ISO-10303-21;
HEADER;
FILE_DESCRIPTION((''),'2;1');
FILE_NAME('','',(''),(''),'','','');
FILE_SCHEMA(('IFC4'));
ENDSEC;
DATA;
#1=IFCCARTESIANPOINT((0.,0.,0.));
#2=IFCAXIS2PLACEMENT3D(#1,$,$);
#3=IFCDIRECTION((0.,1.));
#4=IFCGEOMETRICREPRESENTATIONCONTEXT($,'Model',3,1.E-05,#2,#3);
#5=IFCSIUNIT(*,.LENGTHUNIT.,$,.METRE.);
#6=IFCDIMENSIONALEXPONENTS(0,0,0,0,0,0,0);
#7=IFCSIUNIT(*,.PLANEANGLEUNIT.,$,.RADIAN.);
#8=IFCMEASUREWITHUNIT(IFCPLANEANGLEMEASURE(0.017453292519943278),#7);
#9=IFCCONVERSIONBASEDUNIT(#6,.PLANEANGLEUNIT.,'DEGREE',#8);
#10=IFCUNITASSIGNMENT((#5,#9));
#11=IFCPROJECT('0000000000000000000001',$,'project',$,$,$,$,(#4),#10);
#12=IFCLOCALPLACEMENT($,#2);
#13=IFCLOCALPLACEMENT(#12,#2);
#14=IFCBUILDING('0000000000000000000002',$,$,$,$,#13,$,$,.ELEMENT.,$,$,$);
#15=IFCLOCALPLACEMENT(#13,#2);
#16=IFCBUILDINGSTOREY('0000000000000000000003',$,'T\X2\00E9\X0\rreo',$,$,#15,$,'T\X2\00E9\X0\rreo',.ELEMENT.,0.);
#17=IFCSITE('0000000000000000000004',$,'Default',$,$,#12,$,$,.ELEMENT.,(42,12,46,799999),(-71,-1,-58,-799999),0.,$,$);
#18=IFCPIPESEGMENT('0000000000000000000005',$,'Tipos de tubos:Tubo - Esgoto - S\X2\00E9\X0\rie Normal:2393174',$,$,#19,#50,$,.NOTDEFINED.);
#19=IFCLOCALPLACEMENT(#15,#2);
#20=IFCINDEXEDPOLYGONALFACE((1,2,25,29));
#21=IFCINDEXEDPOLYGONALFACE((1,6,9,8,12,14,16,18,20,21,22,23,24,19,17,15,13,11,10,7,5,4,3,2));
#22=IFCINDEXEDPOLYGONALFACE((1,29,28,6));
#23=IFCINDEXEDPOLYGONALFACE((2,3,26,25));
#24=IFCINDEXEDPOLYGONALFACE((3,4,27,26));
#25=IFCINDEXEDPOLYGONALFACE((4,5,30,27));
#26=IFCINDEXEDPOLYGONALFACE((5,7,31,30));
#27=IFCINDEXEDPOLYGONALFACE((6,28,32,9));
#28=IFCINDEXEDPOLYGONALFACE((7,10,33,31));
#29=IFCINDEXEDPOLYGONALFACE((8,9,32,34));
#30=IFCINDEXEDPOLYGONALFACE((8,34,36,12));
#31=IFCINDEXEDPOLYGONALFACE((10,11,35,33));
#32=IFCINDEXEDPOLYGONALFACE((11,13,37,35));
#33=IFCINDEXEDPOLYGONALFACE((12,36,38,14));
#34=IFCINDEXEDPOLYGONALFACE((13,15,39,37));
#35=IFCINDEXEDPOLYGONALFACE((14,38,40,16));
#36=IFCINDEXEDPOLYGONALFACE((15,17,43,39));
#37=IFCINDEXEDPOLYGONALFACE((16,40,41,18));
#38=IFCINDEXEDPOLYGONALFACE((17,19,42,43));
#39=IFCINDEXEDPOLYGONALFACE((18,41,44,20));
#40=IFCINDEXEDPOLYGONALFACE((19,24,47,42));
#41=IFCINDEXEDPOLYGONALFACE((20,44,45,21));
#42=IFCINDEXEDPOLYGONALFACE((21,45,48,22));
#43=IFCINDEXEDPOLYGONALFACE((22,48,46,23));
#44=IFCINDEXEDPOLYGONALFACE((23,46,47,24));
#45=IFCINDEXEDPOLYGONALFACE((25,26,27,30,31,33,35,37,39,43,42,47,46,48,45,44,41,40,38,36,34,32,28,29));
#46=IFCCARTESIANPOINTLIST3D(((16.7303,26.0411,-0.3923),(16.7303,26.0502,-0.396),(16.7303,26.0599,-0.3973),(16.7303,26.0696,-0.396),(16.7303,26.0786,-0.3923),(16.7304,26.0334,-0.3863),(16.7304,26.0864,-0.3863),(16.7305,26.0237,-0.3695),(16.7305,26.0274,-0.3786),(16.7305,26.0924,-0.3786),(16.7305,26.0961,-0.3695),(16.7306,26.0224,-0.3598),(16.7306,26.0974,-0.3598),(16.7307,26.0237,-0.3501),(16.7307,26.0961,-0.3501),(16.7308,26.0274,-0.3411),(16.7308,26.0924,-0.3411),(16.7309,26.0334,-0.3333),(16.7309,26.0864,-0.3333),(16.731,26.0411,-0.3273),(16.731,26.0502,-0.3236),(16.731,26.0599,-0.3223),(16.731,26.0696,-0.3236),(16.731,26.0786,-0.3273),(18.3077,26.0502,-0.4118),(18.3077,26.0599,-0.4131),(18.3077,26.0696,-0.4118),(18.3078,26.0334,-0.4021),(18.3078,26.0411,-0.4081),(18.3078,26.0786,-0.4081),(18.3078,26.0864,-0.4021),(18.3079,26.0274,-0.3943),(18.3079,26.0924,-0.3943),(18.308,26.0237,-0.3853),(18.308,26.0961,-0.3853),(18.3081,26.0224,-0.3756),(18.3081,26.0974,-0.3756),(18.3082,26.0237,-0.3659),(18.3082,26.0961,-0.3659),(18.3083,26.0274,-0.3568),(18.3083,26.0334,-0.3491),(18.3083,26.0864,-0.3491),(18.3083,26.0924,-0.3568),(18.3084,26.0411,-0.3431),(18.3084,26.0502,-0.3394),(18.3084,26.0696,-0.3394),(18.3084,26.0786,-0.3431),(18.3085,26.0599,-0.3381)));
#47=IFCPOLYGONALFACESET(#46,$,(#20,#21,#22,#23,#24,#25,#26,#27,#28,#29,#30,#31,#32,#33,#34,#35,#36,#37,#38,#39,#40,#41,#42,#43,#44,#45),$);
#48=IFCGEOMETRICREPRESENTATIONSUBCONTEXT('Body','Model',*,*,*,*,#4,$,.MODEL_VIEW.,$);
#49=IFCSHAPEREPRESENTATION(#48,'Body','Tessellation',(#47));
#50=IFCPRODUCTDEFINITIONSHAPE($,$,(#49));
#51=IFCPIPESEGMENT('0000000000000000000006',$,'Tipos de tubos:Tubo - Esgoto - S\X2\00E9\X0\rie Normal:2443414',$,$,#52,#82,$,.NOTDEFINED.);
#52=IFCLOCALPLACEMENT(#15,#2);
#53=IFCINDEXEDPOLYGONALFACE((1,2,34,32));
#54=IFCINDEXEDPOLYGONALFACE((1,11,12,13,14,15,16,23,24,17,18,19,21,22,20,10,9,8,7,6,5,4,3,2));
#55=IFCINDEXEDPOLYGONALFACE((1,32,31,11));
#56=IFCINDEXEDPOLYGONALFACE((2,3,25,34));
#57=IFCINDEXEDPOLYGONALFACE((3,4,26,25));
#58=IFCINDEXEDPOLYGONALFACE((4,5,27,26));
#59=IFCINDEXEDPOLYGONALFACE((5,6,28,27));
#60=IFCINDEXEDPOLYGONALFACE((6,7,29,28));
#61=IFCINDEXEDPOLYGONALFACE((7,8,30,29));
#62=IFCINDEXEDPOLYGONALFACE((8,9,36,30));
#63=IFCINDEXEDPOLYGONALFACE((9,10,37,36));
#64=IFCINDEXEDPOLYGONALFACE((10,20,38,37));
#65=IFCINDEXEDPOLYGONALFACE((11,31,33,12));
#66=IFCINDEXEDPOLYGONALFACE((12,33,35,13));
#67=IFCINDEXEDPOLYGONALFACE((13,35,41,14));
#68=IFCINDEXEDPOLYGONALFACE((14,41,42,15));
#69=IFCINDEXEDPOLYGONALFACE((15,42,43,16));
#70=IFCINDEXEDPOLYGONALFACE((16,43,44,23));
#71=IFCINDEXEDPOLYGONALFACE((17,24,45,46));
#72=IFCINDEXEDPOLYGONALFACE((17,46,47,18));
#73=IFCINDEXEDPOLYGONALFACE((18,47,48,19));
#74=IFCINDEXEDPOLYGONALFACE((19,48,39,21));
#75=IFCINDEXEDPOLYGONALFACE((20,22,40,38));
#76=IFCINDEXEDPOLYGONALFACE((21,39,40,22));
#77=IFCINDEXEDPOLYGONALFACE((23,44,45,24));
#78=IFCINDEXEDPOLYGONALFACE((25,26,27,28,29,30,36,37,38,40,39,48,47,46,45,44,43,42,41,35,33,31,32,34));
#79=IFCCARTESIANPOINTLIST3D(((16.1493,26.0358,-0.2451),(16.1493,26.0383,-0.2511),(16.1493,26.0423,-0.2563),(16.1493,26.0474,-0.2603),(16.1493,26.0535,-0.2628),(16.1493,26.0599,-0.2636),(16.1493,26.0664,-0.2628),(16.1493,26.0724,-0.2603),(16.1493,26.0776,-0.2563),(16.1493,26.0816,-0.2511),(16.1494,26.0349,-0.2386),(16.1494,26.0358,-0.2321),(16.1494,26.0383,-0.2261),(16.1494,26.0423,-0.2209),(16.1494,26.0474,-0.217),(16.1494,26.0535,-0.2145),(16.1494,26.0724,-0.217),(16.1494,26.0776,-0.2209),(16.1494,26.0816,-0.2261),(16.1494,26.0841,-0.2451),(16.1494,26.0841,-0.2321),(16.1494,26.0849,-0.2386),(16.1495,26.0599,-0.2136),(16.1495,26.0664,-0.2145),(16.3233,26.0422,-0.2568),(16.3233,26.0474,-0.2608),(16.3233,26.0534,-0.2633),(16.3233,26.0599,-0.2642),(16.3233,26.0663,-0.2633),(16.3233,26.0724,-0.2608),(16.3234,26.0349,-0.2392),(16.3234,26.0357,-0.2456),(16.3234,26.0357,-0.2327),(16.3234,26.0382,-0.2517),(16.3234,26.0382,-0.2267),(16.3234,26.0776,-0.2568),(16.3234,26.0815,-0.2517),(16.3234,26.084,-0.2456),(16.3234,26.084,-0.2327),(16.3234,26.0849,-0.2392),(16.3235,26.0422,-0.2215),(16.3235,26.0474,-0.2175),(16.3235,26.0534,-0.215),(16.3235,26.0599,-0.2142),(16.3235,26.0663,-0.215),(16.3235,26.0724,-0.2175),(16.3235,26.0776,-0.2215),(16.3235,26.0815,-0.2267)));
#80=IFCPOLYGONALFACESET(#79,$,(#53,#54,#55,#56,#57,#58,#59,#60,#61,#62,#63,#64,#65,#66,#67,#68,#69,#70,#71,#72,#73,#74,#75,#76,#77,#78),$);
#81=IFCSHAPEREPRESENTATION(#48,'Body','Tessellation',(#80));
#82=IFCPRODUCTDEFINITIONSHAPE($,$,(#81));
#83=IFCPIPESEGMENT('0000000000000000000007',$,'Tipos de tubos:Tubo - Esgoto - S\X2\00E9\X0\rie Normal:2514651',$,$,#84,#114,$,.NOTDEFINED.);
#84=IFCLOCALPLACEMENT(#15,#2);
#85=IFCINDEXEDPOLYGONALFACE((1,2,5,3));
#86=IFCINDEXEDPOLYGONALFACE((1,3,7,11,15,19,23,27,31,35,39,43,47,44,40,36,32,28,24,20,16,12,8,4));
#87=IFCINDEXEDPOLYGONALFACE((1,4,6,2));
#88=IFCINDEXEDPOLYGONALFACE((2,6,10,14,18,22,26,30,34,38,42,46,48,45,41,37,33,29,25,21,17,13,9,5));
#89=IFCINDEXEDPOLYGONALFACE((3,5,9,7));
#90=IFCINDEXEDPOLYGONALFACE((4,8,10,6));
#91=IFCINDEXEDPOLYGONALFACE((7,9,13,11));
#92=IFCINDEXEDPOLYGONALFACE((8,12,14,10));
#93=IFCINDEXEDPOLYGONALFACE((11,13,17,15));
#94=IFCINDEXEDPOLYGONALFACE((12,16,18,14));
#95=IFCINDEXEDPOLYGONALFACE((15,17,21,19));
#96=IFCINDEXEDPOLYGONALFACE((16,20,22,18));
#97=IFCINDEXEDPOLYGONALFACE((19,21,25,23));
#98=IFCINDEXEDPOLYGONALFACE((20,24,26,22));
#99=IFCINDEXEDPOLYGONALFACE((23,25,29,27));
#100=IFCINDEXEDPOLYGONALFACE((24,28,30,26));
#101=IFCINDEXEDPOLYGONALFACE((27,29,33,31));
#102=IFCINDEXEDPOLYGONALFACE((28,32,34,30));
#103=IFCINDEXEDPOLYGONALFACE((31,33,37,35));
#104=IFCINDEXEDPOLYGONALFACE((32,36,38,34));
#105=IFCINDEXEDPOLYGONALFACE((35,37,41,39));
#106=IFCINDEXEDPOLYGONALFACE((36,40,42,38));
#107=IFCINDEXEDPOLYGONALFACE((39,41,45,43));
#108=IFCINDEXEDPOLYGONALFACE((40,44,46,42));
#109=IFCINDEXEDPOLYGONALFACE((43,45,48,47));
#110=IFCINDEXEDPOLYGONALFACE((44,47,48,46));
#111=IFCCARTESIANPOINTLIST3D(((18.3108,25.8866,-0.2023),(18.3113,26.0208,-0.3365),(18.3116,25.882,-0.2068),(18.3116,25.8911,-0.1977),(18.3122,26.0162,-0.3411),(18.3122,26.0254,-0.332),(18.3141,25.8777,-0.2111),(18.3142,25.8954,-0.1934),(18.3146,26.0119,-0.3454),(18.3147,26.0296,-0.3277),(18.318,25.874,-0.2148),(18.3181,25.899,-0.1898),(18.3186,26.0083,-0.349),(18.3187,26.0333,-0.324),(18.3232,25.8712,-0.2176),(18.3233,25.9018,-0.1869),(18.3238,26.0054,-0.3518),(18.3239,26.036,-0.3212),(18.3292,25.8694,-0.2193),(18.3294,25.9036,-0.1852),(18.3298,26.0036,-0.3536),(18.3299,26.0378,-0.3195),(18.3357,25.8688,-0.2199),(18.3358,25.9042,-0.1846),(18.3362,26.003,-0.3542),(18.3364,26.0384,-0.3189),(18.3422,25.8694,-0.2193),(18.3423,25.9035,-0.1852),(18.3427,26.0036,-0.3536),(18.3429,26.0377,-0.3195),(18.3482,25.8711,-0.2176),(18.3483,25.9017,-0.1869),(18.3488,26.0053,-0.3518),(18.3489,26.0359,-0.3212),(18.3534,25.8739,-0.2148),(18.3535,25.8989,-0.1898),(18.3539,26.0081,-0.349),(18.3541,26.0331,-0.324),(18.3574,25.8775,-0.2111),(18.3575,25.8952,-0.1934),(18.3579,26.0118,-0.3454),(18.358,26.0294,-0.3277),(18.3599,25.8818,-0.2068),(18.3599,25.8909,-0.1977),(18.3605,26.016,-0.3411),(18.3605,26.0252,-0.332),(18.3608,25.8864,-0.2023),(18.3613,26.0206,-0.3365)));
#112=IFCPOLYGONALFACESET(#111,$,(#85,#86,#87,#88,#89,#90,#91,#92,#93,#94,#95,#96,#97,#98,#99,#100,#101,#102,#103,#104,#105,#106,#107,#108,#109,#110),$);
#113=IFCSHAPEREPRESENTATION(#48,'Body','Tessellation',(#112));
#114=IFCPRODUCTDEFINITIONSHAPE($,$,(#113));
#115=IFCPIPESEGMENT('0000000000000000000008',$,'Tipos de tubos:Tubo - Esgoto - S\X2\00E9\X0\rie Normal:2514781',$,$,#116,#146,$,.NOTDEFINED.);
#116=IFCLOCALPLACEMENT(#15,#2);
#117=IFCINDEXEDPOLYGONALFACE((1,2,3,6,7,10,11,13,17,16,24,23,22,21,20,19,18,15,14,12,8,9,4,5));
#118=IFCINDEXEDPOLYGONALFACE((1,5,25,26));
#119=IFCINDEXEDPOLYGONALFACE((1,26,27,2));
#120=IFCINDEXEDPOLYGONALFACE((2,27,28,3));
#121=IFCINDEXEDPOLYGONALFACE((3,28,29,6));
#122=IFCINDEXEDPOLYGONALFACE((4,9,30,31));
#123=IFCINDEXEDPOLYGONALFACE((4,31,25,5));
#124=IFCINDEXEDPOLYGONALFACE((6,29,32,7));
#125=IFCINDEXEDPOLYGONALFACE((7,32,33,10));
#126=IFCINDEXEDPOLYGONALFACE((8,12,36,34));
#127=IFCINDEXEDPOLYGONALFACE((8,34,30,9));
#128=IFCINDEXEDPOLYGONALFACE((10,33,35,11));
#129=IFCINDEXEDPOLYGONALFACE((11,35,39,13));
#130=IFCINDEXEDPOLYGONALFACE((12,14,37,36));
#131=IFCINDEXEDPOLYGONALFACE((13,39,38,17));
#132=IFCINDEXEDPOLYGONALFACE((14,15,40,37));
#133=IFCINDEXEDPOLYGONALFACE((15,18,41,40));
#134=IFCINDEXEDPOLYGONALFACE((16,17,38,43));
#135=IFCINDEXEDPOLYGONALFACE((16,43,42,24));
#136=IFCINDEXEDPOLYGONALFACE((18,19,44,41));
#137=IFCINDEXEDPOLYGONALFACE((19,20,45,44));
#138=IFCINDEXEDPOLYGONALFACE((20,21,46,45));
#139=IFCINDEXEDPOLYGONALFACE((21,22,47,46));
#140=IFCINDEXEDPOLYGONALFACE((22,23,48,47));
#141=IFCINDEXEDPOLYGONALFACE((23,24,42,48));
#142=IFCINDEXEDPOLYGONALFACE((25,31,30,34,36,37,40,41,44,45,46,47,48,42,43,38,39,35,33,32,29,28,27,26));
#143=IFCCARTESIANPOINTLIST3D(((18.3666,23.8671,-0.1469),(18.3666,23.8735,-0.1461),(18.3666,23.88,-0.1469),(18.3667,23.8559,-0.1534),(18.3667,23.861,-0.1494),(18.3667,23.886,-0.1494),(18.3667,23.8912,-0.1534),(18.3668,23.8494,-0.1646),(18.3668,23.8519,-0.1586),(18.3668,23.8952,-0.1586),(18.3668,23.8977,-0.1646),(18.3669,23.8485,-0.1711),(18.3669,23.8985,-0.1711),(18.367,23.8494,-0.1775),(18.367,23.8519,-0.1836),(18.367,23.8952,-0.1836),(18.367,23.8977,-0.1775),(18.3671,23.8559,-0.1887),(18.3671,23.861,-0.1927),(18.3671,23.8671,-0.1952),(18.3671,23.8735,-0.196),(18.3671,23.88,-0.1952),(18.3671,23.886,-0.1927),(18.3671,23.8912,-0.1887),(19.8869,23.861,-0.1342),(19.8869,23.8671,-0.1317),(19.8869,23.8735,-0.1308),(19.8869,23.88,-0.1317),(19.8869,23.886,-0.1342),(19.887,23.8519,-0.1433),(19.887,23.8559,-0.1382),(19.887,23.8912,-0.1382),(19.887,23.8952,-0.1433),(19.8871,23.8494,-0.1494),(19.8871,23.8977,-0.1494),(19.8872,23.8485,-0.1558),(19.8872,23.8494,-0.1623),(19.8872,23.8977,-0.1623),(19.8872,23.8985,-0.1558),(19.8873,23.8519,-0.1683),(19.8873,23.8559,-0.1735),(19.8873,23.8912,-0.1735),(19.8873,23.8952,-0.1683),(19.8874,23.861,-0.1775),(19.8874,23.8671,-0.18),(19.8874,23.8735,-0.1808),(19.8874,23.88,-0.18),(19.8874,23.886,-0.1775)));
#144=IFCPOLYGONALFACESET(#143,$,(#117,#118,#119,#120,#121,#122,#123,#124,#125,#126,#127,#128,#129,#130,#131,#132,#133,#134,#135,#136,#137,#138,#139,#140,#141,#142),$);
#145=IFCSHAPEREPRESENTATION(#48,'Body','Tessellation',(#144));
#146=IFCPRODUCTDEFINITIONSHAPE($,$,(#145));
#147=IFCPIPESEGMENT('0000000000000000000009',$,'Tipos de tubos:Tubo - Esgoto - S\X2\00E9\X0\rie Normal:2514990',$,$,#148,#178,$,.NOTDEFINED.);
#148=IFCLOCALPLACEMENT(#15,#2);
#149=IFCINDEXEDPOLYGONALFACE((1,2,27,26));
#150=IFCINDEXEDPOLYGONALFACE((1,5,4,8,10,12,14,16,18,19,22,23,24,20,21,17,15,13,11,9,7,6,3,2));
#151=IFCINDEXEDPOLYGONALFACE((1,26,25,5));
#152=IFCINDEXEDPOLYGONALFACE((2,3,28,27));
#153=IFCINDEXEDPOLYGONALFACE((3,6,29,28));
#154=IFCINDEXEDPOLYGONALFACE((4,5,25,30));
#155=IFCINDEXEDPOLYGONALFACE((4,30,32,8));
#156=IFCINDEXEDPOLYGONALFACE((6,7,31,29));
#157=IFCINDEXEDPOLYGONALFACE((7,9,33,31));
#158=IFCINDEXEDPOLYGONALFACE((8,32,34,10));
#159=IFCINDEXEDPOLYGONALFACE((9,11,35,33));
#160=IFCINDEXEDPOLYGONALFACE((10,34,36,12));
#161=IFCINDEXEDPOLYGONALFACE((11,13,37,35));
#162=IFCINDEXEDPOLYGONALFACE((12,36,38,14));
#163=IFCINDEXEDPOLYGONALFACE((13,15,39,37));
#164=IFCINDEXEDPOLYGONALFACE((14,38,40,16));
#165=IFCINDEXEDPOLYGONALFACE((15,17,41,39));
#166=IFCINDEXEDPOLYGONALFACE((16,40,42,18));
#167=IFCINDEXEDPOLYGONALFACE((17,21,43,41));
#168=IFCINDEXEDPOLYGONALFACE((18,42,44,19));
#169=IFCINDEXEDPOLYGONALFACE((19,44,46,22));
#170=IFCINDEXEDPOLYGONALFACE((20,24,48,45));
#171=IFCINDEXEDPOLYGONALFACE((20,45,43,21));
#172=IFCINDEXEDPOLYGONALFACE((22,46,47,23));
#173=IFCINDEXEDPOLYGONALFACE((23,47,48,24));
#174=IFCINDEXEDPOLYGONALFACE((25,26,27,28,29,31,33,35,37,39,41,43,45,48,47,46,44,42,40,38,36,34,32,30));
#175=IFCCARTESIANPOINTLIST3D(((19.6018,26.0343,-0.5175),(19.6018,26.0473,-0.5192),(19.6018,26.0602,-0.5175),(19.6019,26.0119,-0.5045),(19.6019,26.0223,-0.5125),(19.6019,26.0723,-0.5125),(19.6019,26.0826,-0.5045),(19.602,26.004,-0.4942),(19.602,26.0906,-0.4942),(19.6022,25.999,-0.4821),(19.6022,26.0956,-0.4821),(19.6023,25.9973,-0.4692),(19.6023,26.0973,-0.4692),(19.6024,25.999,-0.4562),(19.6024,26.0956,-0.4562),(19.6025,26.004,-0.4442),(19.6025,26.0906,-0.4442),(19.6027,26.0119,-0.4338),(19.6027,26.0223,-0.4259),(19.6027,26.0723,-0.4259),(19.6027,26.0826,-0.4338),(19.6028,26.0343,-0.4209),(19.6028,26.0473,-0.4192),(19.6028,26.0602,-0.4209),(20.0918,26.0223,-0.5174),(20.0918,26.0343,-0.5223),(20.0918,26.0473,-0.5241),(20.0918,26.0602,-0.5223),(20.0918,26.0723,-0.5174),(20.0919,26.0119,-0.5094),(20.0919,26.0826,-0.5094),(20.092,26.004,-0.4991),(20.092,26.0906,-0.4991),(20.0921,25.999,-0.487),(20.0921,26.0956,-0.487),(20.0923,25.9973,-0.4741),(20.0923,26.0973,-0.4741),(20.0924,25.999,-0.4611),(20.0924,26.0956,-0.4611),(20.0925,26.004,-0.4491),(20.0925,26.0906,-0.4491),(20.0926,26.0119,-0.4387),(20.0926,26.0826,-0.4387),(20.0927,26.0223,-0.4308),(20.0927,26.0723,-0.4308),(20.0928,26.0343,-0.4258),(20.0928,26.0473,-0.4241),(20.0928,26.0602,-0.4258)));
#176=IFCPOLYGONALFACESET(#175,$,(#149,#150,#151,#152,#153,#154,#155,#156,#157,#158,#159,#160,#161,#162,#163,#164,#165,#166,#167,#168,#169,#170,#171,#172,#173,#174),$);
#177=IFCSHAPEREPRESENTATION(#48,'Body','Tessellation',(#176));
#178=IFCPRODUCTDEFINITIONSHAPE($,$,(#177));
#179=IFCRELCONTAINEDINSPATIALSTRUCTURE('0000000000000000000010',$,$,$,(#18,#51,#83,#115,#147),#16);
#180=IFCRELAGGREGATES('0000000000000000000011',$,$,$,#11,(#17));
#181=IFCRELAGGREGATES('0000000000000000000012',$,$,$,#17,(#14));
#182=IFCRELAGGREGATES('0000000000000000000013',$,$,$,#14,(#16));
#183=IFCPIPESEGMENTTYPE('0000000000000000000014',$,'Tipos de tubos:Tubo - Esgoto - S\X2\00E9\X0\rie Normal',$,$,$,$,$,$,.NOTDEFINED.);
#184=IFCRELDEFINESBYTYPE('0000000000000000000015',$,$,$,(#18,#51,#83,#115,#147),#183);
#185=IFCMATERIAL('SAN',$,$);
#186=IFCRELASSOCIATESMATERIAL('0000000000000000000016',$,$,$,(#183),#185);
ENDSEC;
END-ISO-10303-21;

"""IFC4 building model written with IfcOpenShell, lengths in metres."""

from ifc_helpers import new_model, entity, si_unit, converted_unit, direction, frame, origin, place, context, subcontext, project, spatial, arc, indexed_curve, outline, extrude, material, type_object, element, save


model = new_model("IFC4")

# Units and contexts
model_context = context("Model", 3, precision=1e-05, world=origin(), true_north=direction((0.0, 1.0)))
body_context = subcontext(model_context, "Body", "Model", "MODEL_VIEW")
ifc_project = project(units=[si_unit("LENGTHUNIT", "METRE"), converted_unit("PLANEANGLEUNIT", "DEGREE", entity("IfcPlaneAngleMeasure", 0.017453292519943278), si_unit("PLANEANGLEUNIT", "RADIAN"), dimensions=[0, 0, 0, 0, 0, 0, 0])], contexts=[model_context])

# Site, building, storey
site_placement = place(None, origin())
site = spatial("IfcSite", under=ifc_project, at=site_placement, Name="Default", CompositionType="ELEMENT", RefLatitude=(42, 12, 46, 799999), RefLongitude=(-71, -1, -58, -799999), RefElevation=0.0)
building_placement = place(site_placement, origin())
building = spatial("IfcBuilding", under=site, at=building_placement, CompositionType="ELEMENT")
storey_placement = place(building_placement, origin())
storey = spatial("IfcBuildingStorey", under=building, at=storey_placement, Name="Térreo", LongName="Térreo", CompositionType="ELEMENT", Elevation=0.0)

# Pipe segments
ifc_material_1 = material(Name="SAN")
pipe_segment_type_1 = type_object("IfcPipeSegmentType", Name="Tipos de tubos:Tubo - Esgoto - Série Normal", PredefinedType="NOTDEFINED", material=ifc_material_1)
pipe_segment_1_placement = place(storey_placement, origin())
element("IfcPipeSegment", 1, at=pipe_segment_1_placement, inside=storey, type_object=pipe_segment_type_1, Name="Tipos de tubos:Tubo - Esgoto - Série Normal:2393174", PredefinedType="NOTDEFINED", context=body_context, shape_type="SweptSolid", body=[
    extrude(outline(indexed_curve([(0.0375, 0.0), (0.0265, 0.0265), (0.0, 0.0375), (-0.0265, 0.0265), (-0.0375, 0.0), (-0.0265, -0.0265), (0.0, -0.0375), (0.0265, -0.0265)], segments=[arc(1, 2, 3), arc(3, 4, 5), arc(5, 6, 7), arc(7, 8, 1)], self_intersect=False)), frame((18.3081, 26.0599, -0.3756), z_axis=(-0.99995, 0.0, 0.01), x_axis=(0.0, 1.0, 0.0)), (0.0, 0.0, 1.0), 1.5775),
])
pipe_segment_2_placement = place(storey_placement, origin())
element("IfcPipeSegment", 2, at=pipe_segment_2_placement, inside=storey, type_object=pipe_segment_type_1, Name="Tipos de tubos:Tubo - Esgoto - Série Normal:2443414", PredefinedType="NOTDEFINED", context=body_context, shape_type="SweptSolid", body=[
    extrude(outline(indexed_curve([(0.025, 0.0), (0.0177, 0.0177), (0.0, 0.025), (-0.0177, 0.0177), (-0.025, 0.0), (-0.0177, -0.0177), (0.0, -0.025), (0.0177, -0.0177)], segments=[arc(1, 2, 3), arc(3, 4, 5), arc(5, 6, 7), arc(7, 8, 1)], self_intersect=False)), frame((16.1494, 26.0599, -0.2386), z_axis=(0.999995, -0.000376, -0.003233), x_axis=(-0.000376, -1.0, 0.0)), (0.0, 0.0, 1.0), 0.174),
])
pipe_segment_3_placement = place(storey_placement, origin())
element("IfcPipeSegment", 3, at=pipe_segment_3_placement, inside=storey, type_object=pipe_segment_type_1, Name="Tipos de tubos:Tubo - Esgoto - Série Normal:2514651", PredefinedType="NOTDEFINED", context=body_context, shape_type="SweptSolid", body=[
    extrude(outline(indexed_curve([(0.025, 0.0), (0.0177, 0.0177), (0.0, 0.025), (-0.0177, 0.0177), (-0.025, 0.0), (-0.0177, -0.0177), (0.0, -0.025), (0.0177, -0.0177)], segments=[arc(1, 2, 3), arc(3, 4, 5), arc(5, 6, 7), arc(7, 8, 1)], self_intersect=False)), frame((18.3363, 26.0207, -0.3365), z_axis=(-0.002925, -0.70694, 0.707268), x_axis=(-0.999991, 0.004138, 0.0)), (0.0, 0.0, 1.0), 0.1898),
])
pipe_segment_4_placement = place(storey_placement, origin())
element("IfcPipeSegment", 4, at=pipe_segment_4_placement, inside=storey, type_object=pipe_segment_type_1, Name="Tipos de tubos:Tubo - Esgoto - Série Normal:2514781", PredefinedType="NOTDEFINED", context=body_context, shape_type="SweptSolid", body=[
    extrude(outline(indexed_curve([(0.025, 0.0), (0.0177, 0.0177), (0.0, 0.025), (-0.0177, 0.0177), (-0.025, 0.0), (-0.0177, -0.0177), (0.0, -0.025), (0.0177, -0.0177)], segments=[arc(1, 2, 3), arc(3, 4, 5), arc(5, 6, 7), arc(7, 8, 1)], self_intersect=False)), frame((18.3669, 23.8735, -0.1711), z_axis=(0.99995, 0.0, 0.010006), x_axis=(0.0, 1.0, 0.0)), (0.0, 0.0, 1.0), 1.5204),
])
pipe_segment_5_placement = place(storey_placement, origin())
element("IfcPipeSegment", 5, at=pipe_segment_5_placement, inside=storey, type_object=pipe_segment_type_1, Name="Tipos de tubos:Tubo - Esgoto - Série Normal:2514990", PredefinedType="NOTDEFINED", context=body_context, shape_type="SweptSolid", body=[
    extrude(outline(indexed_curve([(0.05, 0.0), (0.0354, 0.0354), (0.0, 0.05), (-0.0354, 0.0354), (-0.05, 0.0), (-0.0354, -0.0354), (0.0, -0.05), (0.0354, -0.0354)], segments=[arc(1, 2, 3), arc(3, 4, 5), arc(5, 6, 7), arc(7, 8, 1)], self_intersect=False)), frame((20.0923, 26.0473, -0.4741), z_axis=(-0.99995, 0.0, 0.01), x_axis=(0.0, -1.0, 0.0)), (0.0, 0.0, 1.0), 0.49),
])

save(model, "model.ifc")
